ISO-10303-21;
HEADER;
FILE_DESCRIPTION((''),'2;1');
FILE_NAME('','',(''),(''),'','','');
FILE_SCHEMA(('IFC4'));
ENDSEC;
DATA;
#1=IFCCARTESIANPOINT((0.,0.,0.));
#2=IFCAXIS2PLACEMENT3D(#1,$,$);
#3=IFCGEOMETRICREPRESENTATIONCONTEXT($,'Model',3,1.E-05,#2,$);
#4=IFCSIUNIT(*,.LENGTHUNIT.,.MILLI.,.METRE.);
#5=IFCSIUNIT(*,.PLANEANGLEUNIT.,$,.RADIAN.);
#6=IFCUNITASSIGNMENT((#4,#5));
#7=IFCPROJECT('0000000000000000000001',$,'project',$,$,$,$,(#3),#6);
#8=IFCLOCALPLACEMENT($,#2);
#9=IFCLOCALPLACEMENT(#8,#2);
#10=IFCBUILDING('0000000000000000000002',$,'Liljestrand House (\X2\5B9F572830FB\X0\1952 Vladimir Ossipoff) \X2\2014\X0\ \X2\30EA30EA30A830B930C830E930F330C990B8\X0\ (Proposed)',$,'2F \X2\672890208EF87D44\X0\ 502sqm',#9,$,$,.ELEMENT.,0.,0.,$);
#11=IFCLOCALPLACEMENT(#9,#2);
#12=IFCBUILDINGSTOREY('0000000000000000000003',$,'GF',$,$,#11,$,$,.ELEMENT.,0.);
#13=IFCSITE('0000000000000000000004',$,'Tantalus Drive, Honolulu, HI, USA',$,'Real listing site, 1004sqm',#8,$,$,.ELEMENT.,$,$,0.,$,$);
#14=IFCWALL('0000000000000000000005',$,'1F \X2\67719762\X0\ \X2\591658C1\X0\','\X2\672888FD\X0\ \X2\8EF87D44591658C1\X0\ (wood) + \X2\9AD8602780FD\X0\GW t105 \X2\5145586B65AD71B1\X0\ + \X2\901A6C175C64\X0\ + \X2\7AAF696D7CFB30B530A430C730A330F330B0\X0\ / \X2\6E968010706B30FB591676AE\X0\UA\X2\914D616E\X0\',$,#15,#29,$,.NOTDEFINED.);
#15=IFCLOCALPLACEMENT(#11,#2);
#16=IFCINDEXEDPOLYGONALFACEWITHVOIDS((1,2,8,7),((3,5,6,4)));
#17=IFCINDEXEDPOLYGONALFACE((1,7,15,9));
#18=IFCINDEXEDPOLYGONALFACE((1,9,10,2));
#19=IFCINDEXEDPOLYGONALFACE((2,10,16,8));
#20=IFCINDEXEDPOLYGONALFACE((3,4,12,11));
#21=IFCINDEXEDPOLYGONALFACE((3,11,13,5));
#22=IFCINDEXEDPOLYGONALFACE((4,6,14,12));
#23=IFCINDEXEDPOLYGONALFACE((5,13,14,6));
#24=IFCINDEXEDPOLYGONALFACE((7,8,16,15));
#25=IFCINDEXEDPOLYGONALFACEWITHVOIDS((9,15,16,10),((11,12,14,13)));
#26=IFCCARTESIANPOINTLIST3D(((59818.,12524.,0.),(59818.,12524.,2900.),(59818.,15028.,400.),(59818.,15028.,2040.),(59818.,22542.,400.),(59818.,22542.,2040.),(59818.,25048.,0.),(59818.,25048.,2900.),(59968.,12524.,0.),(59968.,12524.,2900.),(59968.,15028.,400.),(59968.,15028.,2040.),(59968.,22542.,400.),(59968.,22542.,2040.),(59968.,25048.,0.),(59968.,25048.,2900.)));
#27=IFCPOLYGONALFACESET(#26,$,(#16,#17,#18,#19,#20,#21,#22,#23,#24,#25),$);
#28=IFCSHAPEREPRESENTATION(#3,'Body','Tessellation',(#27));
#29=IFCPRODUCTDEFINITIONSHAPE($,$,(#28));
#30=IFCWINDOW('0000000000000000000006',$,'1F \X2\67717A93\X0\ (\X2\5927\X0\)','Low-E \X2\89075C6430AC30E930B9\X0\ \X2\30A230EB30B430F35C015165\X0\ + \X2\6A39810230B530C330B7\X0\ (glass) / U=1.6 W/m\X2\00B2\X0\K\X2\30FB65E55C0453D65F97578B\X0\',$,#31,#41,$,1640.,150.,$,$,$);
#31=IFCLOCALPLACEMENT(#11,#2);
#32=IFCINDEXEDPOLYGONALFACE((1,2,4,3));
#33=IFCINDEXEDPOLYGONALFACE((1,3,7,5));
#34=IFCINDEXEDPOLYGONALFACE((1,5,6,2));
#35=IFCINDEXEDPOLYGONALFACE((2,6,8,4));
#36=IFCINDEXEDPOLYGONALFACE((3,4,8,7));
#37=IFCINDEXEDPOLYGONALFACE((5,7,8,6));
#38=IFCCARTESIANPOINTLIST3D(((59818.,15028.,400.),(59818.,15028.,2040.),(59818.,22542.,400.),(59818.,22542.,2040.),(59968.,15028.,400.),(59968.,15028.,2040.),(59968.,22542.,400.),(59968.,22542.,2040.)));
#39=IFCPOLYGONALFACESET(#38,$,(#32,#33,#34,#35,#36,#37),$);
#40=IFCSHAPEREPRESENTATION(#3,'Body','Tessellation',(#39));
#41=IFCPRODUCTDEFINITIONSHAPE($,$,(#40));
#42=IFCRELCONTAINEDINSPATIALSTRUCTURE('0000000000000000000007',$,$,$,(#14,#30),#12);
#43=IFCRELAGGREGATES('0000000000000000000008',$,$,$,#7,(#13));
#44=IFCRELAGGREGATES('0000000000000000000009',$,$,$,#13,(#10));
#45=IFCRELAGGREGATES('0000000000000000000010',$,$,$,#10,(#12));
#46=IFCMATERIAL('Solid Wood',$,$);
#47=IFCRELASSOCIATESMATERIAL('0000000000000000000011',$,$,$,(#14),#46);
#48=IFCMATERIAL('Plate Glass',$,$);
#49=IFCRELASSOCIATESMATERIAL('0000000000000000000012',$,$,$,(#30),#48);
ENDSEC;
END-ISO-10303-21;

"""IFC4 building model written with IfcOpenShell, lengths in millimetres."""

from ifc_helpers import new_model, si_unit, frame, frame_2d, origin, place, context, project, spatial, rectangle, extrude, material, element, fill, save


model = new_model("IFC4")

# Units and contexts
model_context = context("Model", 3, precision=1e-05, world=origin())
ifc_project = project(units=[si_unit("LENGTHUNIT", "METRE", prefix="MILLI"), si_unit("PLANEANGLEUNIT", "RADIAN")], contexts=[model_context])

# Site, building, storey
site_placement = place(None, origin())
site = spatial("IfcSite", under=ifc_project, at=site_placement, Name="Tantalus Drive, Honolulu, HI, USA", ObjectType="Real listing site, 1004sqm", CompositionType="ELEMENT", RefElevation=0.0)
building_placement = place(site_placement, origin())
building = spatial("IfcBuilding", under=site, at=building_placement, Name="Liljestrand House (実在・1952 Vladimir Ossipoff) — リリエストランド邸 (Proposed)", ObjectType="2F 木造軸組 502sqm", CompositionType="ELEMENT", ElevationOfRefHeight=0.0, ElevationOfTerrain=0.0)
storey_placement = place(building_placement, origin())
storey = spatial("IfcBuildingStorey", under=building, at=storey_placement, Name="GF", CompositionType="ELEMENT", Elevation=0.0)

# Wall, opening, window
ifc_material_1 = material(Name="Solid Wood")
wall_1_placement = place(storey_placement, frame((29909.0, 6262.0, 0.0)))
wall_1 = element("IfcWall", 1, at=wall_1_placement, inside=storey, material=ifc_material_1, Name="1F 東面 外壁", Description="木製 軸組外壁 (wood) + 高性能GW t105 充填断熱 + 通気層 + 窯業系サイディング / 準耐火・外皮UA配慮", PredefinedType="NOTDEFINED", context=model_context, shape_type="SweptSolid", body=[
    extrude(rectangle(XDim=150.0, YDim=12524.0, at=frame_2d((75.0, 6262.0))), frame((29909.0, 6262.0, 0.0)), (0.0, 0.0, 1.0), 2900.0),
])
opening_1_placement = place(storey_placement, frame((29909.0, 7514.0, 200.0)))
opening_1 = element("IfcOpeningElement", 2, at=opening_1_placement, cuts=wall_1, PredefinedType="NOTDEFINED", context=model_context, shape_type="SweptSolid", body=[
    extrude(rectangle(XDim=150.0, YDim=7514.0, at=frame_2d((75.0, 3757.0))), frame((29909.0, 7514.0, 200.0)), (0.0, 0.0, 1.0), 1640.0),
])
ifc_material_2 = material(Name="Plate Glass")
window_1_placement = place(storey_placement, frame((29909.0, 7514.0, 200.0)))
window_1 = element("IfcWindow", 3, at=window_1_placement, inside=storey, material=ifc_material_2, Name="1F 東窓 (大)", Description="Low-E 複層ガラス アルゴン封入 + 樹脂サッシ (glass) / U=1.6 W/m²K・日射取得型", OverallHeight=1640.0, OverallWidth=150.0, context=model_context, shape_type="SweptSolid", body=[
    extrude(rectangle(XDim=150.0, YDim=7514.0, at=frame_2d((75.0, 3757.0))), frame((29909.0, 7514.0, 200.0)), (0.0, 0.0, 1.0), 1640.0),
])
fill(opening_1, window_1)

save(model, "model.ifc")
